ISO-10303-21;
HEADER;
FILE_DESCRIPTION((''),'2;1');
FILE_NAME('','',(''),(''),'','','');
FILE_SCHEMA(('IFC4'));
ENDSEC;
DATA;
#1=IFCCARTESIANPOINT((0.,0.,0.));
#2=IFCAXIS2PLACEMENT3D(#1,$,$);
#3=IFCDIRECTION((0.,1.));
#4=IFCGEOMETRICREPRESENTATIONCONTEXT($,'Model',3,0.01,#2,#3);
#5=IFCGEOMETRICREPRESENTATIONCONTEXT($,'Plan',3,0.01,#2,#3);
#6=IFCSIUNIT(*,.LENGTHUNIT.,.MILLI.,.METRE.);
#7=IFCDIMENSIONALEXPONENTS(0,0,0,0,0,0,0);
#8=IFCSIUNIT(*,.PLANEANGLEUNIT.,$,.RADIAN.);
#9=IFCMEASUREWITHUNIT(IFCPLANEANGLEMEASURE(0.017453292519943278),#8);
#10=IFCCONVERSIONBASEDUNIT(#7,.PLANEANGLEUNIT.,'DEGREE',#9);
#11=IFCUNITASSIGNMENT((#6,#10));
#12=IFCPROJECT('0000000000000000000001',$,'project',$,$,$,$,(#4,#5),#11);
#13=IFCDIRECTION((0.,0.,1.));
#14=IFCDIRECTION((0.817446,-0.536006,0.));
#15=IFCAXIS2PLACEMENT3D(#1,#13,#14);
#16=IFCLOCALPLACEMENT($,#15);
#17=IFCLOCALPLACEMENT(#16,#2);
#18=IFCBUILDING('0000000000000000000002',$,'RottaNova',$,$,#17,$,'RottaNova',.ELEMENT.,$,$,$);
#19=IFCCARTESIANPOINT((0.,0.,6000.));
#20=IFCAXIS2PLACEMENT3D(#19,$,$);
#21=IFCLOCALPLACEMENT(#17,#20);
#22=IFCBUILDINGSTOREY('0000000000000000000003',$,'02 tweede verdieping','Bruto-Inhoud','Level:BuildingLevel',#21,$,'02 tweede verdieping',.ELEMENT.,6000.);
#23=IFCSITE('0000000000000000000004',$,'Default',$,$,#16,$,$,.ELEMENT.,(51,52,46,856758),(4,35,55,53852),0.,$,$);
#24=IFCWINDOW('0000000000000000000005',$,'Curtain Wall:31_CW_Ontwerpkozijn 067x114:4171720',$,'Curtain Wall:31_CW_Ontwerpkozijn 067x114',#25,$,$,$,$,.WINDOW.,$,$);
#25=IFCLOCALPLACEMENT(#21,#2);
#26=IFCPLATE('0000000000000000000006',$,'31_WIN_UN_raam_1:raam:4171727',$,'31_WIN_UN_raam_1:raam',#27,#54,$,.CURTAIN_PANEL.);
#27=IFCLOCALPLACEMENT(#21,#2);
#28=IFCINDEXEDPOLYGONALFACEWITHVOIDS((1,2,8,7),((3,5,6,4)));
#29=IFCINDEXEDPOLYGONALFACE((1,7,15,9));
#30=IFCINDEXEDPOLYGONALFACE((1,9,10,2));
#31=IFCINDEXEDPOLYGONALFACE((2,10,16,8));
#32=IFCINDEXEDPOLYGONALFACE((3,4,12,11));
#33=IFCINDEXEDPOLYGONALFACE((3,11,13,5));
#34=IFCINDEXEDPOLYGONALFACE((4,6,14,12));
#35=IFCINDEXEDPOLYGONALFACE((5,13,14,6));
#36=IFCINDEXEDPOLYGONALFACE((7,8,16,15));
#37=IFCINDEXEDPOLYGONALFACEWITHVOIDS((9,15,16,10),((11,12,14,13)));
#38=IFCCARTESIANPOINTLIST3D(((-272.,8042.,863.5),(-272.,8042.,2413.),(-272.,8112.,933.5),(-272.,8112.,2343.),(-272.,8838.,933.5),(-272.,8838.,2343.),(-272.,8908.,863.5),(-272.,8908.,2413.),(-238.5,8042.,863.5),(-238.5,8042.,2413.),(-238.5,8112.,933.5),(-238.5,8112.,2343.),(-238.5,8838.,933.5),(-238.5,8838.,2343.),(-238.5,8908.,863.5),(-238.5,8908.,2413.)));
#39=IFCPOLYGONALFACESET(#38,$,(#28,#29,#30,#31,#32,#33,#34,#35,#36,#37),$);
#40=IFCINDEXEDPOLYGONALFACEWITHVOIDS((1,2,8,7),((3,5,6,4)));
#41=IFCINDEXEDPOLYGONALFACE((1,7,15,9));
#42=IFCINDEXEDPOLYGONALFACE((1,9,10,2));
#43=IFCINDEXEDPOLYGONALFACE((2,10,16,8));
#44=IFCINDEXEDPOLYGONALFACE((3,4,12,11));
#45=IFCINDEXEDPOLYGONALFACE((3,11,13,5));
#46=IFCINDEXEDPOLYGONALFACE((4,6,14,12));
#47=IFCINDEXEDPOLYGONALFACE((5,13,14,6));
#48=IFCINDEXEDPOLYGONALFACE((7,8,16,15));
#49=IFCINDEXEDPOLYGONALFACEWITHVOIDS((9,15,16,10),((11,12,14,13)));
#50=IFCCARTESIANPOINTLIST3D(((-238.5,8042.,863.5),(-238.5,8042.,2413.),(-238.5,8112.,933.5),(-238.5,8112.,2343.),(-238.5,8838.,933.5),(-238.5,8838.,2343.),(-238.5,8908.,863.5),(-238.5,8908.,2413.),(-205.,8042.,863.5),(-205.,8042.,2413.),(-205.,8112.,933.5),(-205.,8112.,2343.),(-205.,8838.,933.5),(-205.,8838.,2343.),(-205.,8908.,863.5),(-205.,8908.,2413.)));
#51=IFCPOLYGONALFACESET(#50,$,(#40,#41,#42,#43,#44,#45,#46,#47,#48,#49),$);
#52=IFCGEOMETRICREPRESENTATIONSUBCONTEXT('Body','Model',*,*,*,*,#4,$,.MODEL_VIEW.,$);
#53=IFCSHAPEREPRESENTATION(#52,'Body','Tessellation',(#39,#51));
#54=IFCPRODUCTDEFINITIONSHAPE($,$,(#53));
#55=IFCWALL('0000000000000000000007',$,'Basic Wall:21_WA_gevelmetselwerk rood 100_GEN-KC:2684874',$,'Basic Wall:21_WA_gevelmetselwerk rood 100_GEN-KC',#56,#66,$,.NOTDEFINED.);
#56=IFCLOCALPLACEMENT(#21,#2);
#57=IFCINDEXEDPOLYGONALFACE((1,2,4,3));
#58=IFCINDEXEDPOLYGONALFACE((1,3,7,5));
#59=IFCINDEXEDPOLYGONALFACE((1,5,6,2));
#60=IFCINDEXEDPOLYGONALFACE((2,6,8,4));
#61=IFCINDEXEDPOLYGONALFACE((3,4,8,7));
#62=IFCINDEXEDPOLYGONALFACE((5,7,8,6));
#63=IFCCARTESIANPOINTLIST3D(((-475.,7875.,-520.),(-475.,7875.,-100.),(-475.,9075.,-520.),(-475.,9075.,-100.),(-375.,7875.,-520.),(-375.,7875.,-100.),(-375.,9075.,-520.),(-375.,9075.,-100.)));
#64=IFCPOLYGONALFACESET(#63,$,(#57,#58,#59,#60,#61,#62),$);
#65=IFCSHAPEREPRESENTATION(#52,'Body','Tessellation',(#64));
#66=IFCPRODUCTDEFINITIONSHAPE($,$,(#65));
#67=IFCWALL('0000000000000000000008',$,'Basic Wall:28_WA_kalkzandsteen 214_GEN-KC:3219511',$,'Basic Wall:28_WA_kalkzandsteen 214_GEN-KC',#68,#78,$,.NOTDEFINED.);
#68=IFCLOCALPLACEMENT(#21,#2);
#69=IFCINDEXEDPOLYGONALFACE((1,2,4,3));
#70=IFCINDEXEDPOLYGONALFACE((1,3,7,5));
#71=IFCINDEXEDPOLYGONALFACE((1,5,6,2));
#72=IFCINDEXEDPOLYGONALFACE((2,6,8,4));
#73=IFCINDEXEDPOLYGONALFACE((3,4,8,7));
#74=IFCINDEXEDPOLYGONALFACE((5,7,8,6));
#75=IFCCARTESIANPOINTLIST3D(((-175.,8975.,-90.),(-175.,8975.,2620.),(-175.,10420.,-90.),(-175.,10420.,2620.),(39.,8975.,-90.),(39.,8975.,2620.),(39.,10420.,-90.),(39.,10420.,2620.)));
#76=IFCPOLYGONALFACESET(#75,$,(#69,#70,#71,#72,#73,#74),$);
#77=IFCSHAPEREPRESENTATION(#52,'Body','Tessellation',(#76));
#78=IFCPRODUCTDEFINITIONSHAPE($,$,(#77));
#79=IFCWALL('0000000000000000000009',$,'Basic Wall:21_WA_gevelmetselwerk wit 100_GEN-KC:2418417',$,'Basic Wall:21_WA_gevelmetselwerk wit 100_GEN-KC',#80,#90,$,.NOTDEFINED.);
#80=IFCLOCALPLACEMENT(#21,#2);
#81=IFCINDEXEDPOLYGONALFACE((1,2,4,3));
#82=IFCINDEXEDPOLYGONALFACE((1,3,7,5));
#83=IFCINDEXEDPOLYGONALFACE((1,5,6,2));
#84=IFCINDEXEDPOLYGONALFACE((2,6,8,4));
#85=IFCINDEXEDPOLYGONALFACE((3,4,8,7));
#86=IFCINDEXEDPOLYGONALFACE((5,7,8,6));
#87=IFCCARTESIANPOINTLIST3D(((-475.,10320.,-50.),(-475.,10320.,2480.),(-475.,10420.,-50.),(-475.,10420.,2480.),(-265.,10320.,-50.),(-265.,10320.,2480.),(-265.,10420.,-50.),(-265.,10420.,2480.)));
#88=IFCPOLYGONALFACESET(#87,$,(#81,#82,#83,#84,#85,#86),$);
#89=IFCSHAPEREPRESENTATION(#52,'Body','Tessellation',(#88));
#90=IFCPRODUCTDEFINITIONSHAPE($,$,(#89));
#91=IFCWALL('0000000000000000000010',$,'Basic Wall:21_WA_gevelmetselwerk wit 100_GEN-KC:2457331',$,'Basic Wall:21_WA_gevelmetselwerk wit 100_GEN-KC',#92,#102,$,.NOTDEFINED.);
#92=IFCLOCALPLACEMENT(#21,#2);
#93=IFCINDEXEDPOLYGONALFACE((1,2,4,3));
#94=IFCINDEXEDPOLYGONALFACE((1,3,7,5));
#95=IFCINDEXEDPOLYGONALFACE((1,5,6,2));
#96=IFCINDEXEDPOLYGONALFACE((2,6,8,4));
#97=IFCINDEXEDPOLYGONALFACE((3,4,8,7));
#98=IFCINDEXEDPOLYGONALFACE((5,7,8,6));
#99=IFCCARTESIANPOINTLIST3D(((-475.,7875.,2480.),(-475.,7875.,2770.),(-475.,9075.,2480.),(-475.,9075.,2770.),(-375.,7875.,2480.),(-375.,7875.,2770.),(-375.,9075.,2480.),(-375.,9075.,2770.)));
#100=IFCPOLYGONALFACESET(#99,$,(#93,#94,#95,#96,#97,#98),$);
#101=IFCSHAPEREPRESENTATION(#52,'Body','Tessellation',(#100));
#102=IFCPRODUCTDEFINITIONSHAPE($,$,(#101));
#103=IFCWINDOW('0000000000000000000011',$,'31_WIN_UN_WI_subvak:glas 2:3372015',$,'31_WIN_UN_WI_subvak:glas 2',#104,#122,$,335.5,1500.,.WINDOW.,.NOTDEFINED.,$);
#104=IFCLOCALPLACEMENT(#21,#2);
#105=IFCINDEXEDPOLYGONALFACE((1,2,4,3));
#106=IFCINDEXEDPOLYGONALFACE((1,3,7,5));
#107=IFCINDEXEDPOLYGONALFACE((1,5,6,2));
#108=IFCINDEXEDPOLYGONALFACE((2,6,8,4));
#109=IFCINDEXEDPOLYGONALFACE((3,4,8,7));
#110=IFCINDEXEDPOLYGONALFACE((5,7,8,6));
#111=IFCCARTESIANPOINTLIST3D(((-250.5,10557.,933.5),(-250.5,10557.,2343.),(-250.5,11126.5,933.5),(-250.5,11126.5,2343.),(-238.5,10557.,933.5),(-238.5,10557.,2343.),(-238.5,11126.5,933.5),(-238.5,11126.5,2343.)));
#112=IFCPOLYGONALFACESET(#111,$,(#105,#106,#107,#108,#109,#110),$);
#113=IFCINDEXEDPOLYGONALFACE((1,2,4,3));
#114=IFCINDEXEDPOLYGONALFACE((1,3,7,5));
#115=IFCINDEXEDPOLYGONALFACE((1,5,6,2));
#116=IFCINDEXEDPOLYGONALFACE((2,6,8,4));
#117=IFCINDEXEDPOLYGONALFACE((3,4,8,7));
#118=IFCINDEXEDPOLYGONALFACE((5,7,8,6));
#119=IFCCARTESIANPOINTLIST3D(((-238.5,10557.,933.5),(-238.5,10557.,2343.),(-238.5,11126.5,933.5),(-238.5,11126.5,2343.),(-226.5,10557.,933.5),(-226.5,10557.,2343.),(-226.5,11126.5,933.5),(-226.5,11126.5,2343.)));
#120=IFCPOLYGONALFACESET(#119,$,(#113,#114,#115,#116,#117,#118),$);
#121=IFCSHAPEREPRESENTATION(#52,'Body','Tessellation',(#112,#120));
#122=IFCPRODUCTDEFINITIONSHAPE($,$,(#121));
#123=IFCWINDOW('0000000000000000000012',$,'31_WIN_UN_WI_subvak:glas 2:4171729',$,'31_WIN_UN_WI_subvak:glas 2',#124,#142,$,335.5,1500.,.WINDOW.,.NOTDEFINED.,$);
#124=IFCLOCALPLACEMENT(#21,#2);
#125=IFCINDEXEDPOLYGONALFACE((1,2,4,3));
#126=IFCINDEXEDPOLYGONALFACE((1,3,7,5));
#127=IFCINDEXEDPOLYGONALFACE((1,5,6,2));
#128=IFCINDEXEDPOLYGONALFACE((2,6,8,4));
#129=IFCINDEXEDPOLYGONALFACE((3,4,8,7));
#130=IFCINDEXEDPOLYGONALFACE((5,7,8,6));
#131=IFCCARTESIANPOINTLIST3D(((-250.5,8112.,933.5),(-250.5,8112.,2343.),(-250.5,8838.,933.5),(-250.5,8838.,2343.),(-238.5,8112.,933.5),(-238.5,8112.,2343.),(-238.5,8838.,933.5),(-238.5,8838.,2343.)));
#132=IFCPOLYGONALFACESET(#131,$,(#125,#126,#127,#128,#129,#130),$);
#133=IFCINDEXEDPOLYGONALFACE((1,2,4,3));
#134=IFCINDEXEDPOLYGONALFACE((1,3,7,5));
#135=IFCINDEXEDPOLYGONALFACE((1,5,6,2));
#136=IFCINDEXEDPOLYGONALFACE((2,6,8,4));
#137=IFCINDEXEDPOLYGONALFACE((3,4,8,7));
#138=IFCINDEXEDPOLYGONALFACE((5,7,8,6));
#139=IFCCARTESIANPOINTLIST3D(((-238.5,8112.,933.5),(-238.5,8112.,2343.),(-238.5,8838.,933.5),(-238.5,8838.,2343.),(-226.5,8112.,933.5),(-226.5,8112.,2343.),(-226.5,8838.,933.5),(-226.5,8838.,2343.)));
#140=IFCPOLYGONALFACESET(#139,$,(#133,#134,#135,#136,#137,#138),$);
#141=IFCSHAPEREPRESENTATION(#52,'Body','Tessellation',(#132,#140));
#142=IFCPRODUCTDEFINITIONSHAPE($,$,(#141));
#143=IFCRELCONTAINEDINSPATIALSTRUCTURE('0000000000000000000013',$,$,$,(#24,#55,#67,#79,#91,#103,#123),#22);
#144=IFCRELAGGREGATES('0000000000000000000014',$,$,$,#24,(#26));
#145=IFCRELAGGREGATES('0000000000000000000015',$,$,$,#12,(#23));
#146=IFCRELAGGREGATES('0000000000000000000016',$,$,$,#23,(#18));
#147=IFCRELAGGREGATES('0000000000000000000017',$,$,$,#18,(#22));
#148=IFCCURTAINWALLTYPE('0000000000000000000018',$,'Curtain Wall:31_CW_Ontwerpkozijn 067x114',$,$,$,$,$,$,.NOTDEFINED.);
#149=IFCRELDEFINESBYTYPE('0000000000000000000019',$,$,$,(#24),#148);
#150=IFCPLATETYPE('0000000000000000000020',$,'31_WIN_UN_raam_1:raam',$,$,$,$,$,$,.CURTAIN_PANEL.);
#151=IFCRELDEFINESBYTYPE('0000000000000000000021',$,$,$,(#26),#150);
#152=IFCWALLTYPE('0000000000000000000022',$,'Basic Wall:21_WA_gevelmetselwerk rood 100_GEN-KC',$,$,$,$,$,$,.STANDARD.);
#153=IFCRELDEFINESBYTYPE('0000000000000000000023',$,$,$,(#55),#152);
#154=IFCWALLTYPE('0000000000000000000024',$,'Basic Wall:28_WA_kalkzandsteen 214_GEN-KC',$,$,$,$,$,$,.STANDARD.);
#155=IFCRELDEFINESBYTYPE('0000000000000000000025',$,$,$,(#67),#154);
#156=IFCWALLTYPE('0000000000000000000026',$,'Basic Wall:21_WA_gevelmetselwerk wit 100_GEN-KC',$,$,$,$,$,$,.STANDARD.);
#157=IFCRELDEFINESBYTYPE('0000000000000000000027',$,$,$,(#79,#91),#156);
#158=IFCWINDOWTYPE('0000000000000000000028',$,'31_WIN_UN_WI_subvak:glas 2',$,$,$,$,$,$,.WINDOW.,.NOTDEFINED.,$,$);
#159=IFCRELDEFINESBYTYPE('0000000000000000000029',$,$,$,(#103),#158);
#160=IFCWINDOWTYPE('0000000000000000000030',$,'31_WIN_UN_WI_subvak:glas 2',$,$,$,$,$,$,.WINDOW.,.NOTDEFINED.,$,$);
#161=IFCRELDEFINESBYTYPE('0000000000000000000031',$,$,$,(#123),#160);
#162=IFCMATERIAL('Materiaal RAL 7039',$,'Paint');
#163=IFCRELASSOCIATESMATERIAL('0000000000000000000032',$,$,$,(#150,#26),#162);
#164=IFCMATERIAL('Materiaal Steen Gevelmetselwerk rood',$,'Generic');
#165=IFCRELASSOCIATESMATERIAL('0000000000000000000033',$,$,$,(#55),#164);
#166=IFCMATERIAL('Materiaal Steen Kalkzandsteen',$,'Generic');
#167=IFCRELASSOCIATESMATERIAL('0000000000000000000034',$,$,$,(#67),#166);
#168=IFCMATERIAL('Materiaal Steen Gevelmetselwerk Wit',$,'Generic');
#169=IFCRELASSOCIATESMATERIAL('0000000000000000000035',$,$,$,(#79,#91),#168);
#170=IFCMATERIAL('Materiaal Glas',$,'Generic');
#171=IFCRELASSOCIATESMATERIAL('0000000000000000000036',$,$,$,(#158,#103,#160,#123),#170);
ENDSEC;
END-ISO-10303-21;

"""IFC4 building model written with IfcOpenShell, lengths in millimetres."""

from ifc_helpers import new_model, entity, si_unit, converted_unit, direction, frame, origin, place, context, subcontext, project, spatial, indexed_curve, outline, extrude, source, transform, mapped, material, type_object, type_shapes, element, aggregate, save


model = new_model("IFC4")

# Units and contexts
model_context = context("Model", 3, precision=0.01, world=origin(), true_north=direction((0.0, 1.0)))
plan_context = context("Plan", 3, precision=0.01, world=origin(), true_north=direction((0.0, 1.0)))
body_context = subcontext(model_context, "Body", "Model", "MODEL_VIEW")
ifc_project = project(units=[si_unit("LENGTHUNIT", "METRE", prefix="MILLI"), converted_unit("PLANEANGLEUNIT", "DEGREE", entity("IfcPlaneAngleMeasure", 0.017453292519943278), si_unit("PLANEANGLEUNIT", "RADIAN"), dimensions=[0, 0, 0, 0, 0, 0, 0])], contexts=[model_context, plan_context])

# Site, building, storey
site_placement = place(None, frame((0.0, 0.0, 0.0), z_axis=(0.0, 0.0, 1.0), x_axis=(0.817446, -0.536006, 0.0)))
site = spatial("IfcSite", under=ifc_project, at=site_placement, Name="Default", CompositionType="ELEMENT", RefLatitude=(51, 52, 46, 856758), RefLongitude=(4, 35, 55, 53852), RefElevation=0.0)
building_placement = place(site_placement, origin())
building = spatial("IfcBuilding", under=site, at=building_placement, Name="RottaNova", LongName="RottaNova", CompositionType="ELEMENT")
storey_placement = place(building_placement, frame((0.0, 0.0, 6000.0)))
storey = spatial("IfcBuildingStorey", under=building, at=storey_placement, Name="02 tweede verdieping", Description="Bruto-Inhoud", ObjectType="Level:BuildingLevel", LongName="02 tweede verdieping", CompositionType="ELEMENT", Elevation=6000.0)

# Window
curtain_wall_type = type_object("IfcCurtainWallType", Name="Curtain Wall:31_CW_Ontwerpkozijn 067x114", PredefinedType="NOTDEFINED")
window_1_placement = place(storey_placement, frame((0.0, 0.0, -6000.0)))
window_1 = element("IfcWindow", 1, at=window_1_placement, inside=storey, type_object=curtain_wall_type, Name="Curtain Wall:31_CW_Ontwerpkozijn 067x114:4171720", ObjectType="Curtain Wall:31_CW_Ontwerpkozijn 067x114", PredefinedType="WINDOW")

# Plate
ifc_material_1 = material(Name="Materiaal Glas", Category="Generic")
ifc_material_2 = material(Name="Materiaal RAL 7039", Category="Paint")
plate_type_1 = type_object("IfcPlateType", Name="31_WIN_UN_raam_1:raam", PredefinedType="CURTAIN_PANEL", material=ifc_material_2)
shared_shape_1 = source(origin(), body_context, "Body", "SweptSolid", [
    extrude(outline(indexed_curve([(-433.0, -774.7), (433.0, -774.7), (433.0, 774.7), (-433.0, 774.7), (-433.0, -774.7)], self_intersect=False), holes=[indexed_curve([(-363.0, 704.7), (363.0, 704.7), (363.0, -704.8), (-363.0, -704.8), (-363.0, 704.7)], self_intersect=False)]), frame((0.0, -92.0, 774.8), z_axis=(0.0, 1.0, 0.0), x_axis=(1.0, 0.0, 0.0)), (0.0, 0.0, 1.0), 33.5),
    extrude(outline(indexed_curve([(-433.0, -774.7), (433.0, -774.7), (433.0, 774.7), (-433.0, 774.7), (-433.0, -774.7)], self_intersect=False), holes=[indexed_curve([(-363.0, 704.7), (363.0, 704.7), (363.0, -704.8), (-363.0, -704.8), (-363.0, 704.7)], self_intersect=False)]), frame((0.0, -58.5, 774.8), z_axis=(0.0, 1.0, 0.0), x_axis=(1.0, 0.0, 0.0)), (0.0, 0.0, 1.0), 33.5),
])
type_shapes(plate_type_1, [shared_shape_1])
plate_1_placement = place(window_1_placement, frame((-180.0, 8475.0, 6863.5), z_axis=(0.0, 0.0, 1.0), x_axis=(0.0, -1.0, 0.0)))
plate_1 = element("IfcPlate", 2, at=plate_1_placement, type_object=plate_type_1, material=ifc_material_2, Name="31_WIN_UN_raam_1:raam:4171727", ObjectType="31_WIN_UN_raam_1:raam", PredefinedType="CURTAIN_PANEL", context=body_context, shape_type="MappedRepresentation", body=[
    mapped(shared_shape_1, transform((0.0, 0.0, 0.0), scale=1.0)),
])
aggregate(window_1, [plate_1])

# Walls
ifc_material_3 = material(Name="Materiaal Steen Gevelmetselwerk rood", Category="Generic")
wall_type_1 = type_object("IfcWallType", Name="Basic Wall:21_WA_gevelmetselwerk rood 100_GEN-KC", PredefinedType="STANDARD")
wall_1_placement = place(storey_placement, frame((-425.0, 9075.0, -520.0), z_axis=(0.0, 0.0, 1.0), x_axis=(0.0, -1.0, 0.0)))
element("IfcWall", 3, at=wall_1_placement, inside=storey, type_object=wall_type_1, material=ifc_material_3, Name="Basic Wall:21_WA_gevelmetselwerk rood 100_GEN-KC:2684874", ObjectType="Basic Wall:21_WA_gevelmetselwerk rood 100_GEN-KC", PredefinedType="NOTDEFINED", context=body_context, shape_type="SweptSolid", body=[
    extrude(outline(indexed_curve([(1200.0, 50.0), (0.0, 50.0), (0.0, -50.0), (1200.0, -50.0), (1200.0, 50.0)], self_intersect=False)), origin(), (0.0, 0.0, 1.0), 420.0),
])
ifc_material_4 = material(Name="Materiaal Steen Kalkzandsteen", Category="Generic")
wall_type_2 = type_object("IfcWallType", Name="Basic Wall:28_WA_kalkzandsteen 214_GEN-KC", PredefinedType="STANDARD")
wall_2_placement = place(storey_placement, frame((-68.0, 8975.0, -90.0), z_axis=(0.0, 0.0, 1.0), x_axis=(0.0, 1.0, 0.0)))
element("IfcWall", 4, at=wall_2_placement, inside=storey, type_object=wall_type_2, material=ifc_material_4, Name="Basic Wall:28_WA_kalkzandsteen 214_GEN-KC:3219511", ObjectType="Basic Wall:28_WA_kalkzandsteen 214_GEN-KC", PredefinedType="NOTDEFINED", context=body_context, shape_type="SweptSolid", body=[
    extrude(outline(indexed_curve([(1445.0, 107.0), (0.0, 107.0), (0.0, -107.0), (1445.0, -107.0), (1445.0, 107.0)], self_intersect=False)), origin(), (0.0, 0.0, 1.0), 2710.0),
])
ifc_material_5 = material(Name="Materiaal Steen Gevelmetselwerk Wit", Category="Generic")
wall_type_3 = type_object("IfcWallType", Name="Basic Wall:21_WA_gevelmetselwerk wit 100_GEN-KC", PredefinedType="STANDARD")
wall_3_placement = place(storey_placement, frame((-265.0, 10370.0, -50.0), z_axis=(0.0, 0.0, 1.0), x_axis=(-1.0, 0.0, 0.0)))
element("IfcWall", 5, at=wall_3_placement, inside=storey, type_object=wall_type_3, material=ifc_material_5, Name="Basic Wall:21_WA_gevelmetselwerk wit 100_GEN-KC:2418417", ObjectType="Basic Wall:21_WA_gevelmetselwerk wit 100_GEN-KC", PredefinedType="NOTDEFINED", context=body_context, shape_type="SweptSolid", body=[
    extrude(outline(indexed_curve([(210.0, 50.0), (0.0, 50.0), (0.0, -50.0), (210.0, -50.0), (210.0, 50.0)], self_intersect=False)), origin(), (0.0, 0.0, 1.0), 2530.0),
])
wall_4_placement = place(storey_placement, frame((-425.0, 9075.0, 2480.0), z_axis=(0.0, 0.0, 1.0), x_axis=(0.0, -1.0, 0.0)))
element("IfcWall", 6, at=wall_4_placement, inside=storey, type_object=wall_type_3, material=ifc_material_5, Name="Basic Wall:21_WA_gevelmetselwerk wit 100_GEN-KC:2457331", ObjectType="Basic Wall:21_WA_gevelmetselwerk wit 100_GEN-KC", PredefinedType="NOTDEFINED", context=body_context, shape_type="SweptSolid", body=[
    extrude(outline(indexed_curve([(1200.0, 50.0), (0.0, 50.0), (0.0, -50.0), (1200.0, -50.0), (1200.0, 50.0)], self_intersect=False)), origin(), (0.0, 0.0, 1.0), 290.0),
])

# Windows
window_type_1 = type_object("IfcWindowType", Name="31_WIN_UN_WI_subvak:glas 2", PartitioningType="NOTDEFINED", PredefinedType="WINDOW", material=ifc_material_1)
shared_shape_2 = source(origin(), body_context, "Body", "SweptSolid", [
    extrude(outline(indexed_curve([(-284.7, -6.0), (284.7, -6.0), (284.7, 6.0), (-284.7, 6.0), (-284.7, -6.0)], self_intersect=False)), frame((0.0, -6.0, 0.0)), (0.0, 0.0, 1.0), 1409.5),
    extrude(outline(indexed_curve([(-284.8, -6.0), (284.8, -6.0), (284.8, 6.0), (-284.8, 6.0), (-284.8, -6.0)], self_intersect=False)), frame((0.0, 6.0, 0.0)), (0.0, 0.0, 1.0), 1409.5),
])
type_shapes(window_type_1, [shared_shape_2])
window_2_placement = place(storey_placement, frame((-238.5, 10841.7, 933.5), z_axis=(0.0, 0.0, 1.0), x_axis=(0.0, -1.0, 0.0)))
element("IfcWindow", 7, at=window_2_placement, inside=storey, type_object=window_type_1, material=ifc_material_1, Name="31_WIN_UN_WI_subvak:glas 2:3372015", ObjectType="31_WIN_UN_WI_subvak:glas 2", OverallHeight=335.5, OverallWidth=1500.0, PartitioningType="NOTDEFINED", PredefinedType="WINDOW", context=body_context, shape_type="MappedRepresentation", body=[
    mapped(shared_shape_2, transform((0.0, 0.0, 0.0), scale=1.0)),
])
window_type_2 = type_object("IfcWindowType", Name="31_WIN_UN_WI_subvak:glas 2", PartitioningType="NOTDEFINED", PredefinedType="WINDOW", material=ifc_material_1)
shared_shape_3 = source(origin(), body_context, "Body", "SweptSolid", [
    extrude(outline(indexed_curve([(-363.0, -6.0), (363.0, -6.0), (363.0, 6.0), (-363.0, 6.0), (-363.0, -6.0)], self_intersect=False)), frame((0.0, -6.0, 0.0)), (0.0, 0.0, 1.0), 1409.5),
    extrude(outline(indexed_curve([(-363.0, -6.0), (363.0, -6.0), (363.0, 6.0), (-363.0, 6.0), (-363.0, -6.0)], self_intersect=False)), frame((0.0, 6.0, 0.0)), (0.0, 0.0, 1.0), 1409.5),
])
type_shapes(window_type_2, [shared_shape_3])
window_3_placement = place(storey_placement, frame((-238.5, 8475.0, 933.5), z_axis=(0.0, 0.0, 1.0), x_axis=(0.0, -1.0, 0.0)))
element("IfcWindow", 8, at=window_3_placement, inside=storey, type_object=window_type_2, material=ifc_material_1, Name="31_WIN_UN_WI_subvak:glas 2:4171729", ObjectType="31_WIN_UN_WI_subvak:glas 2", OverallHeight=335.5, OverallWidth=1500.0, PartitioningType="NOTDEFINED", PredefinedType="WINDOW", context=body_context, shape_type="MappedRepresentation", body=[
    mapped(shared_shape_3, transform((0.0, 0.0, 0.0), scale=1.0)),
])

save(model, "model.ifc")
